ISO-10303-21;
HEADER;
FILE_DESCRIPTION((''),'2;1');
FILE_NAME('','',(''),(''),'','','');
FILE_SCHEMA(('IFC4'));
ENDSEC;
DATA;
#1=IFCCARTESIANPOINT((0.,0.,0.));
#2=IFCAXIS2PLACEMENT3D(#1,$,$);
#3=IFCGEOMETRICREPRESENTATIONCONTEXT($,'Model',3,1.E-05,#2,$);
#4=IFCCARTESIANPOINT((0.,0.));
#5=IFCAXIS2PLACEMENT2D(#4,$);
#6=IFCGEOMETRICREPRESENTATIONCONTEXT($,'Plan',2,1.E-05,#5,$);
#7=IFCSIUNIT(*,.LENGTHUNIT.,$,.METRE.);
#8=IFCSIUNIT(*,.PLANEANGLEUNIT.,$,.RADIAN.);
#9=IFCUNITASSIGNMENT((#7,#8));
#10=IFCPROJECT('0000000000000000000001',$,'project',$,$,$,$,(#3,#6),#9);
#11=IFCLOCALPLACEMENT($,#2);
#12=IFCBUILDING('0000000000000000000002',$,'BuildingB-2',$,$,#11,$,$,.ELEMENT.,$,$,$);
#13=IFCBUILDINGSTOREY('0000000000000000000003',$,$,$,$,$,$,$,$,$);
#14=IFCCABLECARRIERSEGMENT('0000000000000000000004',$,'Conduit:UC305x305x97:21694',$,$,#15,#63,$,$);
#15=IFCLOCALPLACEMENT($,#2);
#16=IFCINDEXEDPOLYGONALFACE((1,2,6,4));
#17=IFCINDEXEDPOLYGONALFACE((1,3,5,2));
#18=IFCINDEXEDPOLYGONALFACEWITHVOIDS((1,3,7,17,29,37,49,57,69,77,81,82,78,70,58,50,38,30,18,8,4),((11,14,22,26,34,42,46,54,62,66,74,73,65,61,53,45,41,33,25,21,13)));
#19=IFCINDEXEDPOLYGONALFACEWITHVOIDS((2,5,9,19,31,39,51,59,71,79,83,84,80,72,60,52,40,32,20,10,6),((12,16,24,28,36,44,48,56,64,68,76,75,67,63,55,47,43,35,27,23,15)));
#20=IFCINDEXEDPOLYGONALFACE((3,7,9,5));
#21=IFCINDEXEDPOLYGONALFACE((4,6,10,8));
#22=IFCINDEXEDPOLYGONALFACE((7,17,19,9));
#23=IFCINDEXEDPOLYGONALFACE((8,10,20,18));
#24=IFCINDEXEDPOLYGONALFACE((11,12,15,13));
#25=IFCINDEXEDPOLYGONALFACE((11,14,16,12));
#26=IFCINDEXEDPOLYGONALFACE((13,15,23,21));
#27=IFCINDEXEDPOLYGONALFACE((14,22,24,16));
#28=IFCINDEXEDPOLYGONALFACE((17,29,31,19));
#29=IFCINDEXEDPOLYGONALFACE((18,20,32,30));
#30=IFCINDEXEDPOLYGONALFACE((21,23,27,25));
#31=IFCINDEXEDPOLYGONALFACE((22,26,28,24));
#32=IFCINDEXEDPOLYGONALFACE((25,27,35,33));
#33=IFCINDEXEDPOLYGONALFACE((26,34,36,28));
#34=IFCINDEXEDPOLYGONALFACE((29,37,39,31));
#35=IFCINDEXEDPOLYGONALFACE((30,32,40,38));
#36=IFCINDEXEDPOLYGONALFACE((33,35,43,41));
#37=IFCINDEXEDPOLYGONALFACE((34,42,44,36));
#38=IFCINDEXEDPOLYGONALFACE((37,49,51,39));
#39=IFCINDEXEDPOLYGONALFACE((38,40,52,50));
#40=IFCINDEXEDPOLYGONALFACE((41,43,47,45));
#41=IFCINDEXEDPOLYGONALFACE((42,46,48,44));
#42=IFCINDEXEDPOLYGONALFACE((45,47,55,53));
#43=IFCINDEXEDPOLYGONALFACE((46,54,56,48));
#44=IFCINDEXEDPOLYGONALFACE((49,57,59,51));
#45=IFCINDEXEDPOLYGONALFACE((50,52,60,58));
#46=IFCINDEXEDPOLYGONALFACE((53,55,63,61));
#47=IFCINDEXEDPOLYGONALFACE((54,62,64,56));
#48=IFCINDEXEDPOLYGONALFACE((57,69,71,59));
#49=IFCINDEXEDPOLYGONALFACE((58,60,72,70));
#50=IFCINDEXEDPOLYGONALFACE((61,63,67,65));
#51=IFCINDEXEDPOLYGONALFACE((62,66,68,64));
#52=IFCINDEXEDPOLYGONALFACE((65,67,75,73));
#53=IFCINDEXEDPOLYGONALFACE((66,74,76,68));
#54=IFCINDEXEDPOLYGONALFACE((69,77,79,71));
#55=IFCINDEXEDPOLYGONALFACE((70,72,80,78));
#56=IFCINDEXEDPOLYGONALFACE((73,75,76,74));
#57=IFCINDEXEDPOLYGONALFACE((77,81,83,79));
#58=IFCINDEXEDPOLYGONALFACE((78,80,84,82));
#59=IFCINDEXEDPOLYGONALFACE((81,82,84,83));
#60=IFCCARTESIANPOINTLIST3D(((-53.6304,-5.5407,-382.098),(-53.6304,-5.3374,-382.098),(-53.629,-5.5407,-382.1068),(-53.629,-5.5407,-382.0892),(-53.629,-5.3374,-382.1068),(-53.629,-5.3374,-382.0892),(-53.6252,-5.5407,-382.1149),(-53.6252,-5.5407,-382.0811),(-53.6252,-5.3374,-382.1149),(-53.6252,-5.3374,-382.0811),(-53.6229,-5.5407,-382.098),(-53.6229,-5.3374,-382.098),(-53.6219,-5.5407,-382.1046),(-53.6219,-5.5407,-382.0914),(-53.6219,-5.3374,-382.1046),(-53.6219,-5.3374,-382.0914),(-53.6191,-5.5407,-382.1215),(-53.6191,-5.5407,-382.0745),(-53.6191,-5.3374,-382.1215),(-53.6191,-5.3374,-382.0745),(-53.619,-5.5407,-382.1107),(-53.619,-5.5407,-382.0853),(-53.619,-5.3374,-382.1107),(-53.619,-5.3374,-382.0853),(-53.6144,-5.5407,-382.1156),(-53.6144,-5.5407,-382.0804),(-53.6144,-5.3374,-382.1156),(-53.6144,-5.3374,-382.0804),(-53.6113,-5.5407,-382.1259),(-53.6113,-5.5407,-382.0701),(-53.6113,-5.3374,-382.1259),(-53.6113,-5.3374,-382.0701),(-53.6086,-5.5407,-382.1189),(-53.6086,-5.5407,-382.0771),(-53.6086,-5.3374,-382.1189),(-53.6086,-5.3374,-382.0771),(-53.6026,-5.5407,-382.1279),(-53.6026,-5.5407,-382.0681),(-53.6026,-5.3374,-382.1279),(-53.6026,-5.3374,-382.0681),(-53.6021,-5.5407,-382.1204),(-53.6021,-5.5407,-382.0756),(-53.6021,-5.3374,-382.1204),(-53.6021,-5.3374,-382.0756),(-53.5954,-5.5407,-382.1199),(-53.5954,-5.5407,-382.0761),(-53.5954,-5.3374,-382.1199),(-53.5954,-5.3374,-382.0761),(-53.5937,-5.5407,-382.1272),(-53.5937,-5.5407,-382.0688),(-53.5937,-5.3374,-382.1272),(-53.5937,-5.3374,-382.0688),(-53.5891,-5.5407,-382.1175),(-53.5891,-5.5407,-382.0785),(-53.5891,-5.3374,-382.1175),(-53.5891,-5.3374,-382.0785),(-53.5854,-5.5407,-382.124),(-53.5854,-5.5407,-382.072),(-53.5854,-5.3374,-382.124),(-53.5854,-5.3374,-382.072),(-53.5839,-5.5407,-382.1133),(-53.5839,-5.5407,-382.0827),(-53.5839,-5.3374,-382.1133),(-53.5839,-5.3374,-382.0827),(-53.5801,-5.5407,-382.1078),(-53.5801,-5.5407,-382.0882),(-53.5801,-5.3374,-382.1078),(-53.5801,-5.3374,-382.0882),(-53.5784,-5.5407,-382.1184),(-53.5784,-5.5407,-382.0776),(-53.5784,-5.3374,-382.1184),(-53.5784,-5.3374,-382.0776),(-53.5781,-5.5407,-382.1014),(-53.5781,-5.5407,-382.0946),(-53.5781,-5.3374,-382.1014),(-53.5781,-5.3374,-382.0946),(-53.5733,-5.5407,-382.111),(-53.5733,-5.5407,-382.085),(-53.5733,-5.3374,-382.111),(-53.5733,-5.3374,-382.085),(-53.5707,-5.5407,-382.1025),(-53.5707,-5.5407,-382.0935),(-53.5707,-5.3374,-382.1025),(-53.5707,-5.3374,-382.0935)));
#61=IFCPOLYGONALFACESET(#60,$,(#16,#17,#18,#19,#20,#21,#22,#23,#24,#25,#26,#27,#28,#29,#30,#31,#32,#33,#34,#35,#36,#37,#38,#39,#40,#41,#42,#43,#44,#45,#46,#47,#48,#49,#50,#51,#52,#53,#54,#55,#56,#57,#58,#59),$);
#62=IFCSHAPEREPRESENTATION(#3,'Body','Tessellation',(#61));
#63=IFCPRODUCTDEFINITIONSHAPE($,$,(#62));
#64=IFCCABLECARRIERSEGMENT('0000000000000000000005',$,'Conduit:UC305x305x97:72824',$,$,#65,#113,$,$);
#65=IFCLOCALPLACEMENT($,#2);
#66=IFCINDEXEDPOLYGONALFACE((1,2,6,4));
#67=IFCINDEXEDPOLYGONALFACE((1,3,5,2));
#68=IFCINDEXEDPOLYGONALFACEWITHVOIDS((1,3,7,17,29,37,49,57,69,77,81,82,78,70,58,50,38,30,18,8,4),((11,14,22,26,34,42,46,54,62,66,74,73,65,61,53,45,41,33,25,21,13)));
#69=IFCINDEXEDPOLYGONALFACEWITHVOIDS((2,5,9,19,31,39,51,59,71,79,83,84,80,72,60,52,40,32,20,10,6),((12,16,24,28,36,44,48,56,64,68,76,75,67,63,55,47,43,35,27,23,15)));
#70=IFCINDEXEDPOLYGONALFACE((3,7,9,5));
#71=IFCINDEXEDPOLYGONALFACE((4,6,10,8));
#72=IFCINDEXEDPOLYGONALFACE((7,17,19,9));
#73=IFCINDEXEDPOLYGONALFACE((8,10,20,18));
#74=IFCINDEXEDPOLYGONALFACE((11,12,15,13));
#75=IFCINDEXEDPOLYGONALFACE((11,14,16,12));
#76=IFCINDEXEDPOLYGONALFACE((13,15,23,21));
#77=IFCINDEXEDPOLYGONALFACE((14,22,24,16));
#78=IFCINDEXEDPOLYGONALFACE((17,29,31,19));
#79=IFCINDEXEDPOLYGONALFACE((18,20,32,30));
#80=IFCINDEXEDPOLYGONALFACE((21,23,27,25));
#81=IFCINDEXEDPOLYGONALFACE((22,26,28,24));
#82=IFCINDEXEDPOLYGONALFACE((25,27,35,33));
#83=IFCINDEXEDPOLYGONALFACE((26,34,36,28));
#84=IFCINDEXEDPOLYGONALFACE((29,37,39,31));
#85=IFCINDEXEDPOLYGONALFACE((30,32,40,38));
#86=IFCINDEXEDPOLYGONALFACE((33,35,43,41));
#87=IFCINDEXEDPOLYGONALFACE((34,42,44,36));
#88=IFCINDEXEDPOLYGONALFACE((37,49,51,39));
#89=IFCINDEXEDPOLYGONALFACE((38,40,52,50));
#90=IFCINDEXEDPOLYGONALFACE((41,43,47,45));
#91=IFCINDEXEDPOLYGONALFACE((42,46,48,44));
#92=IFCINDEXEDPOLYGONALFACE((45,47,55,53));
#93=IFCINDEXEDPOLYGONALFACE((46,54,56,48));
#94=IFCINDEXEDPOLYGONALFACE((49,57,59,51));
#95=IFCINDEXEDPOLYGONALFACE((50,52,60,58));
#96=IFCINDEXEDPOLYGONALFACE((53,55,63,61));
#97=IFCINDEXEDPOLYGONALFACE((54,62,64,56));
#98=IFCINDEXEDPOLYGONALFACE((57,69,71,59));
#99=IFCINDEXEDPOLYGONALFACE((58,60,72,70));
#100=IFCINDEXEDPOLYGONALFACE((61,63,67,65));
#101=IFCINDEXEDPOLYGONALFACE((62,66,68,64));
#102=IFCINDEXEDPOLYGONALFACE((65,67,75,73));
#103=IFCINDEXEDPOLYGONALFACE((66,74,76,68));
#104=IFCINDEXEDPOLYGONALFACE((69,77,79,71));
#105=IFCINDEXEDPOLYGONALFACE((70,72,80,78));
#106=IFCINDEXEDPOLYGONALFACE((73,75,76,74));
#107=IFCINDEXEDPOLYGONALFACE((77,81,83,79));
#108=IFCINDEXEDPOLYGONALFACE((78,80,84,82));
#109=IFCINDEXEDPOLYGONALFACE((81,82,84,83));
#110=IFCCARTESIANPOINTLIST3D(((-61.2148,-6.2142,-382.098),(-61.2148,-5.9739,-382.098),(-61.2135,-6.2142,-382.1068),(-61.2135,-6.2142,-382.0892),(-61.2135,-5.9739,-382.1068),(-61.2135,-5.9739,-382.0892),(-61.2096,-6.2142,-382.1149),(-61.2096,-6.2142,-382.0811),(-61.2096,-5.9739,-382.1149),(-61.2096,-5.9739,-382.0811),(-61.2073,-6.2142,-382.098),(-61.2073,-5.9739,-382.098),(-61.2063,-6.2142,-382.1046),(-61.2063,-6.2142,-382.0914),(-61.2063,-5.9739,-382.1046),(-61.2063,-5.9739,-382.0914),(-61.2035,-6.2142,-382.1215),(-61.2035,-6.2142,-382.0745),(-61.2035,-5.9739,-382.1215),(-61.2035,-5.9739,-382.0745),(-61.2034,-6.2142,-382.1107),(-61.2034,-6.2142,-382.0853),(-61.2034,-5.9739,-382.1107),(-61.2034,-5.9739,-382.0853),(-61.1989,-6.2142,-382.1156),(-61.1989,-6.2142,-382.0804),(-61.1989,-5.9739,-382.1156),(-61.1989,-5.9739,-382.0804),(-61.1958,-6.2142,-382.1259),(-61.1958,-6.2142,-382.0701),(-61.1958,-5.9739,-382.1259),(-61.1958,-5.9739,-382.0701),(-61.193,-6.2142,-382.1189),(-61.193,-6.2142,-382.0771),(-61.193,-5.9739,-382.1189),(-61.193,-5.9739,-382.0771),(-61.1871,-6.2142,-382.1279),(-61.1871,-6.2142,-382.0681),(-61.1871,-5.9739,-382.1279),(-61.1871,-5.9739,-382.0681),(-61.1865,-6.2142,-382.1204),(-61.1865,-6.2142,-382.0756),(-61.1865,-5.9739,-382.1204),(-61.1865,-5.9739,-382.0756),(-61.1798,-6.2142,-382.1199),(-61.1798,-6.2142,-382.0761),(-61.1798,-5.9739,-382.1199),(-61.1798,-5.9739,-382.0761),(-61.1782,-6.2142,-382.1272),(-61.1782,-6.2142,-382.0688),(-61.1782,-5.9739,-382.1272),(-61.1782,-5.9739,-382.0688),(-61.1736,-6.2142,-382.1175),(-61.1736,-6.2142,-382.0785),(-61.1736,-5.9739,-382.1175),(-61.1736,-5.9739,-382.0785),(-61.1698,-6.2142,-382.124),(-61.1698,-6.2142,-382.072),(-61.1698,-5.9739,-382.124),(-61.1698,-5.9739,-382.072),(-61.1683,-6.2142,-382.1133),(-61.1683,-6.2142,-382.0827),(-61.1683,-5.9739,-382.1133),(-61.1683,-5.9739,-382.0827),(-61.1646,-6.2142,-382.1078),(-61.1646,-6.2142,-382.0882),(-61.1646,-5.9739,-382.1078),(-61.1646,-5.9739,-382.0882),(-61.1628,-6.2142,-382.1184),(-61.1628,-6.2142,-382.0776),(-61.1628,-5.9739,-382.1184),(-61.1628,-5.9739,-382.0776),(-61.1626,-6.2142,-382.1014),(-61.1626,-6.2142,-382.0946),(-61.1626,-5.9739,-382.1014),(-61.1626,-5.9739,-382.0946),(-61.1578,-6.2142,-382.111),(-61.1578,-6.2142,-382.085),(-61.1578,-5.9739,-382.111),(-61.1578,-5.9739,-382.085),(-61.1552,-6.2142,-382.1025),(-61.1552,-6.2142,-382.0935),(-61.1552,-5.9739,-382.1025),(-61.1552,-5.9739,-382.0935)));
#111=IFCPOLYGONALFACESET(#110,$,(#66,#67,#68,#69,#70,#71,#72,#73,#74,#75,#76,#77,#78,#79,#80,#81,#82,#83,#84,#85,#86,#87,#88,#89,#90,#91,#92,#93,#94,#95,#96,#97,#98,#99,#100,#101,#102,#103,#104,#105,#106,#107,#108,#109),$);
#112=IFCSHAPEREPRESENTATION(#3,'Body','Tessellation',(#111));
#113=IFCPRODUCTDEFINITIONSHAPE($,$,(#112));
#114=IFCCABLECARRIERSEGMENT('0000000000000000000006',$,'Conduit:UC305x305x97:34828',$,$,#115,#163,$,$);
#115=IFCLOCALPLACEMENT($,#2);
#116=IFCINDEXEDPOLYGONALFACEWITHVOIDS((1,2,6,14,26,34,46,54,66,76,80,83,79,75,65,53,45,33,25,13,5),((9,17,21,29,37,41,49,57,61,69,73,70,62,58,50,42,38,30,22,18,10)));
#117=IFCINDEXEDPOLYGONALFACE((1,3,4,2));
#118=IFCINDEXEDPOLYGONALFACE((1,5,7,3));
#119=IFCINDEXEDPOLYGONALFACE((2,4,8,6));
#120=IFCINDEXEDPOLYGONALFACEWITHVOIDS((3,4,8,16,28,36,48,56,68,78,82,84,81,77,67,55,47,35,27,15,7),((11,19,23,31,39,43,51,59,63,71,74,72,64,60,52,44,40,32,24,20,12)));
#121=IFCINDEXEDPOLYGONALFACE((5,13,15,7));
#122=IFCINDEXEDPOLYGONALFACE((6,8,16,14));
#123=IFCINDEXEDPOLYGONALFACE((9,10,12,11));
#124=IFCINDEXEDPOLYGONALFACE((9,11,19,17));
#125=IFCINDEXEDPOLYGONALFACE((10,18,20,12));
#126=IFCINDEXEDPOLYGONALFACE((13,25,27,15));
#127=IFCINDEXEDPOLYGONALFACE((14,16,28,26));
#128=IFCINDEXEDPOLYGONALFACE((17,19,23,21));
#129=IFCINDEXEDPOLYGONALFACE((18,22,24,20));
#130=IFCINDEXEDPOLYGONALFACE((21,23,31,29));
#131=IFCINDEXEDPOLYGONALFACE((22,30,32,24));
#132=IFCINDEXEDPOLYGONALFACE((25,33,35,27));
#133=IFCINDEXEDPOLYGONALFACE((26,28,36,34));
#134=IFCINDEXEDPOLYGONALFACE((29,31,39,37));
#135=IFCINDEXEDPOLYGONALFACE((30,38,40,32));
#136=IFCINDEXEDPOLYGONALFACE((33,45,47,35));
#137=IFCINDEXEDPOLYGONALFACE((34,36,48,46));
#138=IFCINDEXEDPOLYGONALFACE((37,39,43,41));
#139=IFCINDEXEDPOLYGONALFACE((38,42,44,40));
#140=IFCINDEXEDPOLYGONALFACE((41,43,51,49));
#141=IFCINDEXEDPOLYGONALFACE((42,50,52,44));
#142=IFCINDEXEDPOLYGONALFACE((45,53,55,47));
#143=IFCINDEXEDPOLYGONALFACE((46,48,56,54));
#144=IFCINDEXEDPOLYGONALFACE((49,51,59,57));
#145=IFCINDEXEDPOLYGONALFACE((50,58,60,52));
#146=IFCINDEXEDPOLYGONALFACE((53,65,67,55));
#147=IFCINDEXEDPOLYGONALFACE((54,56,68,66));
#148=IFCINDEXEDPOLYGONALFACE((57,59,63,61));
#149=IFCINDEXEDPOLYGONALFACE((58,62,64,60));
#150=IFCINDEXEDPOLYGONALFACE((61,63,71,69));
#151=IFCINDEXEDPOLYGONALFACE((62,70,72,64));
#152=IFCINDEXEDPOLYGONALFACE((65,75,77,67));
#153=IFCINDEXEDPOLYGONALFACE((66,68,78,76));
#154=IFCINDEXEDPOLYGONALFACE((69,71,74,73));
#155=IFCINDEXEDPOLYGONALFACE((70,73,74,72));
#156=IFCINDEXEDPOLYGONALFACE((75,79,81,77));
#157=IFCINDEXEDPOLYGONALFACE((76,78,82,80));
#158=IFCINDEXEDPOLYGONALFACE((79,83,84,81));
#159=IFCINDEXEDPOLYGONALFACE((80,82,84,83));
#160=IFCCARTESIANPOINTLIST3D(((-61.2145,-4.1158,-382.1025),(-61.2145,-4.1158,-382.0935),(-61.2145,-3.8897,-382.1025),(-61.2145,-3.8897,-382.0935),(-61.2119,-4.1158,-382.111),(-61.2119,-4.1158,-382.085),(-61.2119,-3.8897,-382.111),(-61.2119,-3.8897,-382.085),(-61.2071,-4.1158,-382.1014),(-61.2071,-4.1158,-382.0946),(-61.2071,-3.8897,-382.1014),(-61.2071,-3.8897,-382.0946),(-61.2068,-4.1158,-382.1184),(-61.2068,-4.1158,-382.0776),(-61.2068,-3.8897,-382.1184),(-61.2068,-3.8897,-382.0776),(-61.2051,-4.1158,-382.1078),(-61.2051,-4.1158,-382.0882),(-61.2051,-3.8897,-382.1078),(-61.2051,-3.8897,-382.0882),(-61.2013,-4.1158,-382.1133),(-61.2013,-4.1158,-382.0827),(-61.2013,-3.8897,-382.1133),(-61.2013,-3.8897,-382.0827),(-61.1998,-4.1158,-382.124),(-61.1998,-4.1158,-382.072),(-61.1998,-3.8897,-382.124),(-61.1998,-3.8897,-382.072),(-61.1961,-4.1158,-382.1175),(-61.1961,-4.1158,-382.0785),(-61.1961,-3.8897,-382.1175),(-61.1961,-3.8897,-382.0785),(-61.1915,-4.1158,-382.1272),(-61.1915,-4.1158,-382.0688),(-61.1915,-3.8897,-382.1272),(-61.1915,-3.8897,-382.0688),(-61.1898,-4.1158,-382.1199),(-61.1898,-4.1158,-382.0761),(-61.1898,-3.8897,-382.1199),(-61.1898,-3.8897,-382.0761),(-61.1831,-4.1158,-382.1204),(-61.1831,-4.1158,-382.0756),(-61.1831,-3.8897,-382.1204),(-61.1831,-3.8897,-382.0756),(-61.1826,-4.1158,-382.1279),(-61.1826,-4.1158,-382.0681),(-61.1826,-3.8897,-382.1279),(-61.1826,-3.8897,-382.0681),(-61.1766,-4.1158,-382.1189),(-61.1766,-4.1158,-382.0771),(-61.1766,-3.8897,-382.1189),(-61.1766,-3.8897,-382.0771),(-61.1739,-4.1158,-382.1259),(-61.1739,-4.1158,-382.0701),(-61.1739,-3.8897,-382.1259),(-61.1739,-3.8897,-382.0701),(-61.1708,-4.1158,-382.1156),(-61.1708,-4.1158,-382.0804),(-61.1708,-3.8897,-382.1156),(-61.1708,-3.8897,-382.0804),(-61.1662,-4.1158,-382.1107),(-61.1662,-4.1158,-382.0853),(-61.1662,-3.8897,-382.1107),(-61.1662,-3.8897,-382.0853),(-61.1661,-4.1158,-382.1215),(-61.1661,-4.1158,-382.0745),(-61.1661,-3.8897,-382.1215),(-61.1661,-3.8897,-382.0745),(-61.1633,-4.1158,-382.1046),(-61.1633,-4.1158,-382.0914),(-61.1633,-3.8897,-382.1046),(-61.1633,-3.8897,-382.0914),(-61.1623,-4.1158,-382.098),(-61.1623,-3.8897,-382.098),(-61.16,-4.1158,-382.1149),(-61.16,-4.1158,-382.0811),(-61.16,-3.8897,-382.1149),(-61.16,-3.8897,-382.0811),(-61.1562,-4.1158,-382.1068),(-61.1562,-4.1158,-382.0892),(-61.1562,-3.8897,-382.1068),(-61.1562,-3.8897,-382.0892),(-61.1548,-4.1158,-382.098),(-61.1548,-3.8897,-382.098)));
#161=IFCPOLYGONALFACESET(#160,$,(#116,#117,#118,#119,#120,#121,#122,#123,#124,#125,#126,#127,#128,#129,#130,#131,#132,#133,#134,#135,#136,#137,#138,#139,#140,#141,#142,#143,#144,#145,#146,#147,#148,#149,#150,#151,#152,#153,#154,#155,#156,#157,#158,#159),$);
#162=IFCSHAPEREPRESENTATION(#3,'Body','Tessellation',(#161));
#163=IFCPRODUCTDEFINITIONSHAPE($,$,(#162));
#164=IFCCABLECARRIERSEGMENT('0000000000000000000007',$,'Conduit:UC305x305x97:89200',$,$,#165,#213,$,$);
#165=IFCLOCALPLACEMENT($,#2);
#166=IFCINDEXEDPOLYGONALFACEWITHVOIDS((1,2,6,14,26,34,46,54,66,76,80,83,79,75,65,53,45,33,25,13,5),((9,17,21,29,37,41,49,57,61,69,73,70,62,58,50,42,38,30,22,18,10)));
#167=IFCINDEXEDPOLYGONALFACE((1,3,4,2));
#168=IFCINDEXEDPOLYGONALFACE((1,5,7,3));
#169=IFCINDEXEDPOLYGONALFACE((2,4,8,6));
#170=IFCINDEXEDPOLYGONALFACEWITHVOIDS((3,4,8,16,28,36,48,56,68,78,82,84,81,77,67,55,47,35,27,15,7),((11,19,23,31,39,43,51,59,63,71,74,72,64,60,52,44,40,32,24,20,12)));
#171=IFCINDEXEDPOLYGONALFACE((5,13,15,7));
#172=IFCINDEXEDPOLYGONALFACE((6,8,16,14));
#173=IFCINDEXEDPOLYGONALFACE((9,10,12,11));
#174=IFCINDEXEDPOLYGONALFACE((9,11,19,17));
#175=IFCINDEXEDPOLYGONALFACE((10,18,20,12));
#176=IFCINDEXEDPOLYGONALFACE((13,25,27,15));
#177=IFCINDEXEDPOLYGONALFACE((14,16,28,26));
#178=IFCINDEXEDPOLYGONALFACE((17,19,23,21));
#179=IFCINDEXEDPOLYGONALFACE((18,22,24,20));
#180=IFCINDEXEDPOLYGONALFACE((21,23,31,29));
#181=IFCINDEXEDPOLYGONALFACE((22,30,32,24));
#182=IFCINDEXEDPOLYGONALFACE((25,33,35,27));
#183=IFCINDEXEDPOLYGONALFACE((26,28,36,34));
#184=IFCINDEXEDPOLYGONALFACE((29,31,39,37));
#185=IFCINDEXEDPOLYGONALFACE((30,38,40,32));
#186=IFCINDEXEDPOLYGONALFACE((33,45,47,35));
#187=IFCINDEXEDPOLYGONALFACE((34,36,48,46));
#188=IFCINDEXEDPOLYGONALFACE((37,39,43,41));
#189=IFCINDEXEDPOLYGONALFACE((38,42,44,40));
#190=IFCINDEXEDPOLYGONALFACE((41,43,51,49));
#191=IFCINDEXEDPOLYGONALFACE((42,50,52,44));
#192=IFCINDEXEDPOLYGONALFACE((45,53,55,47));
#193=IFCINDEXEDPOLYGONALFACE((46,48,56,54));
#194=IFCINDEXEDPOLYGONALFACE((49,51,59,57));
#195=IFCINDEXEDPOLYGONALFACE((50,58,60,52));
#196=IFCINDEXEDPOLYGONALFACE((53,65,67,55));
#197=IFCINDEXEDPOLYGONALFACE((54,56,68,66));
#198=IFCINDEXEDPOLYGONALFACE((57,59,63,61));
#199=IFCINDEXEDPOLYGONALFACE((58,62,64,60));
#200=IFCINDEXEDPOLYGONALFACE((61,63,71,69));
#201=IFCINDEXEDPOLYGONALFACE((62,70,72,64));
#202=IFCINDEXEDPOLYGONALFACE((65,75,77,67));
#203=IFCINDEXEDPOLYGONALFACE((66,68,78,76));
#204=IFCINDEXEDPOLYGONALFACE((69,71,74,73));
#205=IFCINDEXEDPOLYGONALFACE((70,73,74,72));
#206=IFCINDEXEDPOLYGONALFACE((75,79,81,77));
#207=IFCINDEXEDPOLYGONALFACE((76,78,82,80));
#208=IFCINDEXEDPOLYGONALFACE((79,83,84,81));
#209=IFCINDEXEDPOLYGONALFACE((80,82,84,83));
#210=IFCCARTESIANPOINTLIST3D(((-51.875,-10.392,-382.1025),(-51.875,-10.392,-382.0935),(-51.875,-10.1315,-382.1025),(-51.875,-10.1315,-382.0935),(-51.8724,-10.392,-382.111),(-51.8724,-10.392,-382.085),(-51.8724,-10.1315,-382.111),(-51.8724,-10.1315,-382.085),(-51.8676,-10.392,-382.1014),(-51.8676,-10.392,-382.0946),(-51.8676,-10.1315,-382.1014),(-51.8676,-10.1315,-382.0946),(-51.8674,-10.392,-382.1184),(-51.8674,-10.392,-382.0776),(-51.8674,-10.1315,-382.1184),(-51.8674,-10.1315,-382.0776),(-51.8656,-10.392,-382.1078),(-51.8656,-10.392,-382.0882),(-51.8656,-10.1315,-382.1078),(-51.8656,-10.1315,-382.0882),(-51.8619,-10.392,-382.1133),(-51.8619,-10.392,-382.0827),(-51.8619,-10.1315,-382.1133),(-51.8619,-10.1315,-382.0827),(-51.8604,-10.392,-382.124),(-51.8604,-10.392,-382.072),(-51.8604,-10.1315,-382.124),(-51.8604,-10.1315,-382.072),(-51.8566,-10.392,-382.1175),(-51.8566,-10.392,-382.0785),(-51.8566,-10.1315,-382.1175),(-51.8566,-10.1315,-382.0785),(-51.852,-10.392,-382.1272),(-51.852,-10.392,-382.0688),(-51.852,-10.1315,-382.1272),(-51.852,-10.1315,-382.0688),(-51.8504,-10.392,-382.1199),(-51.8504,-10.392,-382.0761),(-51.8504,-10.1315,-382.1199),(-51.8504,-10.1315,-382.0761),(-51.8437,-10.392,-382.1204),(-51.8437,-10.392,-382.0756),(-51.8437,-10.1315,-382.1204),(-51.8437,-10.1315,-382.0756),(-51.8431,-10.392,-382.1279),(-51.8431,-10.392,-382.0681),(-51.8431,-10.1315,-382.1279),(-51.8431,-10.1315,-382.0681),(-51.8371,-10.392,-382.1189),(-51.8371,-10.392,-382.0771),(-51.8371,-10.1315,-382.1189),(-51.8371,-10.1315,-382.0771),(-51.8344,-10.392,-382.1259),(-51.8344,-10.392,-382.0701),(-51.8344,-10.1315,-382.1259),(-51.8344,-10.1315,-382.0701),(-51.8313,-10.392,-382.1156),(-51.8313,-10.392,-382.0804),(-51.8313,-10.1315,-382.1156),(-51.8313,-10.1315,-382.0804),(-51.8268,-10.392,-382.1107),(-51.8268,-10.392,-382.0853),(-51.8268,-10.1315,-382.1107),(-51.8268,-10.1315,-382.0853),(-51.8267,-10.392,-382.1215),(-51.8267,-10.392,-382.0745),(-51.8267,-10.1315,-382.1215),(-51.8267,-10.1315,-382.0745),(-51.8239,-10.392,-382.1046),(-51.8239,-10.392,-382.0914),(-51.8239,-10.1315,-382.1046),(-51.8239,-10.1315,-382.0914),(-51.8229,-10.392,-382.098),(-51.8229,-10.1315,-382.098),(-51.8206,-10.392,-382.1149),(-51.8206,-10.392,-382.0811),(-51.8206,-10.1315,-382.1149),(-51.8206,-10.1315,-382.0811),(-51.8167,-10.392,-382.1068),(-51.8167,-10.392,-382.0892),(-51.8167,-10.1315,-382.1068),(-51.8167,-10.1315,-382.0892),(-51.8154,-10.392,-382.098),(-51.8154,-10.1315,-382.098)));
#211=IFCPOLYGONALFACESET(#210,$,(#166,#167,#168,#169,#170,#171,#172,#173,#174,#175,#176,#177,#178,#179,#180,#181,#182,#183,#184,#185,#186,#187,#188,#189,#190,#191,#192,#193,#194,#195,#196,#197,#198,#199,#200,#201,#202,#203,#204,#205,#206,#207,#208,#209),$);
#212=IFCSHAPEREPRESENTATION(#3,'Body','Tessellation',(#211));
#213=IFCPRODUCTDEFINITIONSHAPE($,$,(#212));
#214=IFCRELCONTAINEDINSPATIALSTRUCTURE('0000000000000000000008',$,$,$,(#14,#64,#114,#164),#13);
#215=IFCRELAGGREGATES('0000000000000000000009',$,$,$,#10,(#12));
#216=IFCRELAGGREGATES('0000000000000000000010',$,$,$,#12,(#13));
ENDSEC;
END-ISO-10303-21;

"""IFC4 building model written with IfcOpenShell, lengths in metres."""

from ifc_helpers import new_model, entity, si_unit, origin, origin_2d, place, context, project, spatial, element, save


model = new_model("IFC4")

# Units and contexts
model_context = context("Model", 3, precision=1e-05, world=origin())
plan_context = context("Plan", 2, precision=1e-05, world=origin_2d())
ifc_project = project(units=[si_unit("LENGTHUNIT", "METRE"), si_unit("PLANEANGLEUNIT", "RADIAN")], contexts=[model_context, plan_context])

# Building, storey
building_placement = place(None, origin())
building = spatial("IfcBuilding", under=ifc_project, at=building_placement, Name="BuildingB-2", CompositionType="ELEMENT")
storey = spatial("IfcBuildingStorey", under=building)

# Cable carrier segments
element("IfcCableCarrierSegment", 1, inside=storey, Name="Conduit:UC305x305x97:21694", context=model_context, shape_type="AdvancedSweptSolid", body=[
    entity("IfcSweptDiskSolid", entity("IfcCompositeCurve", [entity("IfcCompositeCurveSegment", "CONTINUOUS", False, entity("IfcPolyline", [entity("IfcCartesianPoint", [53.6004, 5.5407, 382.098]), entity("IfcCartesianPoint", [53.6004, 5.3374, 382.098])]))], False), 0.03, 0.0225),
])
element("IfcCableCarrierSegment", 2, inside=storey, Name="Conduit:UC305x305x97:72824", context=model_context, shape_type="AdvancedSweptSolid", body=[
    entity("IfcSweptDiskSolid", entity("IfcCompositeCurve", [entity("IfcCompositeCurveSegment", "CONTINUOUS", False, entity("IfcPolyline", [entity("IfcCartesianPoint", [61.1848, 6.2142, 382.098]), entity("IfcCartesianPoint", [61.1848, 5.9739, 382.098])]))], False), 0.03, 0.0225),
])
element("IfcCableCarrierSegment", 3, inside=storey, Name="Conduit:UC305x305x97:34828", context=model_context, shape_type="AdvancedSweptSolid", body=[
    entity("IfcSweptDiskSolid", entity("IfcCompositeCurve", [entity("IfcCompositeCurveSegment", "CONTINUOUS", False, entity("IfcPolyline", [entity("IfcCartesianPoint", [61.1848, 3.8897, 382.098]), entity("IfcCartesianPoint", [61.1848, 4.1158, 382.098])]))], False), 0.03, 0.0225),
])
element("IfcCableCarrierSegment", 4, inside=storey, Name="Conduit:UC305x305x97:89200", context=model_context, shape_type="AdvancedSweptSolid", body=[
    entity("IfcSweptDiskSolid", entity("IfcCompositeCurve", [entity("IfcCompositeCurveSegment", "CONTINUOUS", False, entity("IfcPolyline", [entity("IfcCartesianPoint", [51.8454, 10.1315, 382.098]), entity("IfcCartesianPoint", [51.8454, 10.392, 382.098])]))], False), 0.03, 0.0225),
])

save(model, "model.ifc")
